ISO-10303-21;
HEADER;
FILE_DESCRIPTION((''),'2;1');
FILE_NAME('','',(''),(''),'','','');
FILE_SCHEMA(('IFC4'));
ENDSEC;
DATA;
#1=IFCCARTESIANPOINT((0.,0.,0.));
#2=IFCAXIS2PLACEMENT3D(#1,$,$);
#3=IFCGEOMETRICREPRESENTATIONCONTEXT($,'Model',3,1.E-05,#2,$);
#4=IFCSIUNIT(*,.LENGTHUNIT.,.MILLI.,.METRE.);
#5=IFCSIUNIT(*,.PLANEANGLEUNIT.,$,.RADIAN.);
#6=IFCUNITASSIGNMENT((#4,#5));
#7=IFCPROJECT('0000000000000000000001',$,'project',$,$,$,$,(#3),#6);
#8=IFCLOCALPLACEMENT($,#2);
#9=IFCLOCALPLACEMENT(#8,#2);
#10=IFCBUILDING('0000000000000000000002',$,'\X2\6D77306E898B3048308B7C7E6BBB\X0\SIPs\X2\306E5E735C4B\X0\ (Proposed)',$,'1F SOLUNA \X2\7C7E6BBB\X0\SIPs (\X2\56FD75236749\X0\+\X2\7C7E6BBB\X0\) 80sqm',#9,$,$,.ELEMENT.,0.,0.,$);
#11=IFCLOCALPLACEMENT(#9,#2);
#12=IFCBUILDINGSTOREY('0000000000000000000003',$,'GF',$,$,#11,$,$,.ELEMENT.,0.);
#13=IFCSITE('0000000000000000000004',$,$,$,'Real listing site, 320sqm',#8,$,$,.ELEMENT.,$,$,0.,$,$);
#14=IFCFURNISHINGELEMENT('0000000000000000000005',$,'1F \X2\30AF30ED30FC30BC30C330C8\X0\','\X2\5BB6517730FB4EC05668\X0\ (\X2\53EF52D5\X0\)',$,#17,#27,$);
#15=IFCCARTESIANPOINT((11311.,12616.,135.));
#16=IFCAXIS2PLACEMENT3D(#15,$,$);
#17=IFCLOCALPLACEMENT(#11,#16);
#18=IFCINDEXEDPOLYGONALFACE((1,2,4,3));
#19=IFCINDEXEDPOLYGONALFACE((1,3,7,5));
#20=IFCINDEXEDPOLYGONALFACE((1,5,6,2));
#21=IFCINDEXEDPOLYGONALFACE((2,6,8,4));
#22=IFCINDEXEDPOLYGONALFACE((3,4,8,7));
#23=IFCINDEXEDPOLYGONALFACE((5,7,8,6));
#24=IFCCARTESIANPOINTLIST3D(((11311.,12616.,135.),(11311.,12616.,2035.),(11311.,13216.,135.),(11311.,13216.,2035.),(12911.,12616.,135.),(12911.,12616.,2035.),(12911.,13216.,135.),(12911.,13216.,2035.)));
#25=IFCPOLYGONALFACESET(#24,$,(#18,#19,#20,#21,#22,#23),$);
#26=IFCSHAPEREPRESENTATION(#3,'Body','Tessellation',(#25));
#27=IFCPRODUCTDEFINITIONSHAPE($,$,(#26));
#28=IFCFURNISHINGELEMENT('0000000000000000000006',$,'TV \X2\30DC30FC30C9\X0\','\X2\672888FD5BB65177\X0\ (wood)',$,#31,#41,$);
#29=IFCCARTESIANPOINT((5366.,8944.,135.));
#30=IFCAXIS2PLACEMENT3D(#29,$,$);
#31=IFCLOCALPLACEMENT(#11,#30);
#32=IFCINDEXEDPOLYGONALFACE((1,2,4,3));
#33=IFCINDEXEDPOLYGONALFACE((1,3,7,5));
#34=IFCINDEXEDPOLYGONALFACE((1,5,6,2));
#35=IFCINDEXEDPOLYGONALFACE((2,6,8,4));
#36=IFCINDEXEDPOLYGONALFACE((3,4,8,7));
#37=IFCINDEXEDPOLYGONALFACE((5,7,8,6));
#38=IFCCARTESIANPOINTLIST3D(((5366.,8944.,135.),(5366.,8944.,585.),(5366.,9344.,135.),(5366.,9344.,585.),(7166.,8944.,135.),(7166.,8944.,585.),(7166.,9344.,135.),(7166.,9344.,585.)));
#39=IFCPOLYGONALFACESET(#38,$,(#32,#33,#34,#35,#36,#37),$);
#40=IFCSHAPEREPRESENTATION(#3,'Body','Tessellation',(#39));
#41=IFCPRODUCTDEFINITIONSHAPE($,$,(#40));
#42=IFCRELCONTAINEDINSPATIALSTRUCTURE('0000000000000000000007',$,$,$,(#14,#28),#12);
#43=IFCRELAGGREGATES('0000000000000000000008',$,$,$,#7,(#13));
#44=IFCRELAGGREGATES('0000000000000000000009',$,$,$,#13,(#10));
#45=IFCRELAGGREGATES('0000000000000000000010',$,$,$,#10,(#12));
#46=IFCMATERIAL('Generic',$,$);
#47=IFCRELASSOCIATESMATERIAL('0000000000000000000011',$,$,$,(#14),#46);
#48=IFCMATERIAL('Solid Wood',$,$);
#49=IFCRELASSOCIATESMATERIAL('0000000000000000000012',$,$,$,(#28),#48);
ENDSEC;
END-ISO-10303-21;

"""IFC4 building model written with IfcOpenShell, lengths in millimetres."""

from ifc_helpers import new_model, si_unit, frame, frame_2d, origin, place, context, project, spatial, rectangle, extrude, material, element, save


model = new_model("IFC4")

# Units and contexts
model_context = context("Model", 3, precision=1e-05, world=origin())
ifc_project = project(units=[si_unit("LENGTHUNIT", "METRE", prefix="MILLI"), si_unit("PLANEANGLEUNIT", "RADIAN")], contexts=[model_context])

# Site, building, storey
site_placement = place(None, origin())
site = spatial("IfcSite", under=ifc_project, at=site_placement, ObjectType="Real listing site, 320sqm", CompositionType="ELEMENT", RefElevation=0.0)
building_placement = place(site_placement, origin())
building = spatial("IfcBuilding", under=site, at=building_placement, Name="海の見える籾殻SIPsの平屋 (Proposed)", ObjectType="1F SOLUNA 籾殻SIPs (国産杉+籾殻) 80sqm", CompositionType="ELEMENT", ElevationOfRefHeight=0.0, ElevationOfTerrain=0.0)
storey_placement = place(building_placement, origin())
storey = spatial("IfcBuildingStorey", under=building, at=storey_placement, Name="GF", CompositionType="ELEMENT", Elevation=0.0)

# Shared definitions
ifc_material_1 = material(Name="Solid Wood")

# Shared definitions
ifc_material_2 = material(Name="Generic")

# Furnishing elements
furnishing_1_placement = place(storey_placement, frame((11311.0, 12616.0, 135.0)))
element("IfcFurnishingElement", 1, at=furnishing_1_placement, inside=storey, material=ifc_material_2, Name="1F クローゼット", Description="家具・什器 (可動)", context=model_context, shape_type="SweptSolid", body=[
    extrude(rectangle(XDim=1600.0, YDim=600.0, at=frame_2d((800.0, 300.0))), frame((11311.0, 12616.0, 135.0)), (0.0, 0.0, 1.0), 1900.0),
])
furnishing_2_placement = place(storey_placement, frame((5366.0, 8944.0, 135.0)))
element("IfcFurnishingElement", 2, at=furnishing_2_placement, inside=storey, material=ifc_material_1, Name="TV ボード", Description="木製家具 (wood)", context=model_context, shape_type="SweptSolid", body=[
    extrude(rectangle(XDim=1800.0, YDim=400.0, at=frame_2d((900.0, 200.0))), frame((5366.0, 8944.0, 135.0)), (0.0, 0.0, 1.0), 450.0),
])

save(model, "model.ifc")
